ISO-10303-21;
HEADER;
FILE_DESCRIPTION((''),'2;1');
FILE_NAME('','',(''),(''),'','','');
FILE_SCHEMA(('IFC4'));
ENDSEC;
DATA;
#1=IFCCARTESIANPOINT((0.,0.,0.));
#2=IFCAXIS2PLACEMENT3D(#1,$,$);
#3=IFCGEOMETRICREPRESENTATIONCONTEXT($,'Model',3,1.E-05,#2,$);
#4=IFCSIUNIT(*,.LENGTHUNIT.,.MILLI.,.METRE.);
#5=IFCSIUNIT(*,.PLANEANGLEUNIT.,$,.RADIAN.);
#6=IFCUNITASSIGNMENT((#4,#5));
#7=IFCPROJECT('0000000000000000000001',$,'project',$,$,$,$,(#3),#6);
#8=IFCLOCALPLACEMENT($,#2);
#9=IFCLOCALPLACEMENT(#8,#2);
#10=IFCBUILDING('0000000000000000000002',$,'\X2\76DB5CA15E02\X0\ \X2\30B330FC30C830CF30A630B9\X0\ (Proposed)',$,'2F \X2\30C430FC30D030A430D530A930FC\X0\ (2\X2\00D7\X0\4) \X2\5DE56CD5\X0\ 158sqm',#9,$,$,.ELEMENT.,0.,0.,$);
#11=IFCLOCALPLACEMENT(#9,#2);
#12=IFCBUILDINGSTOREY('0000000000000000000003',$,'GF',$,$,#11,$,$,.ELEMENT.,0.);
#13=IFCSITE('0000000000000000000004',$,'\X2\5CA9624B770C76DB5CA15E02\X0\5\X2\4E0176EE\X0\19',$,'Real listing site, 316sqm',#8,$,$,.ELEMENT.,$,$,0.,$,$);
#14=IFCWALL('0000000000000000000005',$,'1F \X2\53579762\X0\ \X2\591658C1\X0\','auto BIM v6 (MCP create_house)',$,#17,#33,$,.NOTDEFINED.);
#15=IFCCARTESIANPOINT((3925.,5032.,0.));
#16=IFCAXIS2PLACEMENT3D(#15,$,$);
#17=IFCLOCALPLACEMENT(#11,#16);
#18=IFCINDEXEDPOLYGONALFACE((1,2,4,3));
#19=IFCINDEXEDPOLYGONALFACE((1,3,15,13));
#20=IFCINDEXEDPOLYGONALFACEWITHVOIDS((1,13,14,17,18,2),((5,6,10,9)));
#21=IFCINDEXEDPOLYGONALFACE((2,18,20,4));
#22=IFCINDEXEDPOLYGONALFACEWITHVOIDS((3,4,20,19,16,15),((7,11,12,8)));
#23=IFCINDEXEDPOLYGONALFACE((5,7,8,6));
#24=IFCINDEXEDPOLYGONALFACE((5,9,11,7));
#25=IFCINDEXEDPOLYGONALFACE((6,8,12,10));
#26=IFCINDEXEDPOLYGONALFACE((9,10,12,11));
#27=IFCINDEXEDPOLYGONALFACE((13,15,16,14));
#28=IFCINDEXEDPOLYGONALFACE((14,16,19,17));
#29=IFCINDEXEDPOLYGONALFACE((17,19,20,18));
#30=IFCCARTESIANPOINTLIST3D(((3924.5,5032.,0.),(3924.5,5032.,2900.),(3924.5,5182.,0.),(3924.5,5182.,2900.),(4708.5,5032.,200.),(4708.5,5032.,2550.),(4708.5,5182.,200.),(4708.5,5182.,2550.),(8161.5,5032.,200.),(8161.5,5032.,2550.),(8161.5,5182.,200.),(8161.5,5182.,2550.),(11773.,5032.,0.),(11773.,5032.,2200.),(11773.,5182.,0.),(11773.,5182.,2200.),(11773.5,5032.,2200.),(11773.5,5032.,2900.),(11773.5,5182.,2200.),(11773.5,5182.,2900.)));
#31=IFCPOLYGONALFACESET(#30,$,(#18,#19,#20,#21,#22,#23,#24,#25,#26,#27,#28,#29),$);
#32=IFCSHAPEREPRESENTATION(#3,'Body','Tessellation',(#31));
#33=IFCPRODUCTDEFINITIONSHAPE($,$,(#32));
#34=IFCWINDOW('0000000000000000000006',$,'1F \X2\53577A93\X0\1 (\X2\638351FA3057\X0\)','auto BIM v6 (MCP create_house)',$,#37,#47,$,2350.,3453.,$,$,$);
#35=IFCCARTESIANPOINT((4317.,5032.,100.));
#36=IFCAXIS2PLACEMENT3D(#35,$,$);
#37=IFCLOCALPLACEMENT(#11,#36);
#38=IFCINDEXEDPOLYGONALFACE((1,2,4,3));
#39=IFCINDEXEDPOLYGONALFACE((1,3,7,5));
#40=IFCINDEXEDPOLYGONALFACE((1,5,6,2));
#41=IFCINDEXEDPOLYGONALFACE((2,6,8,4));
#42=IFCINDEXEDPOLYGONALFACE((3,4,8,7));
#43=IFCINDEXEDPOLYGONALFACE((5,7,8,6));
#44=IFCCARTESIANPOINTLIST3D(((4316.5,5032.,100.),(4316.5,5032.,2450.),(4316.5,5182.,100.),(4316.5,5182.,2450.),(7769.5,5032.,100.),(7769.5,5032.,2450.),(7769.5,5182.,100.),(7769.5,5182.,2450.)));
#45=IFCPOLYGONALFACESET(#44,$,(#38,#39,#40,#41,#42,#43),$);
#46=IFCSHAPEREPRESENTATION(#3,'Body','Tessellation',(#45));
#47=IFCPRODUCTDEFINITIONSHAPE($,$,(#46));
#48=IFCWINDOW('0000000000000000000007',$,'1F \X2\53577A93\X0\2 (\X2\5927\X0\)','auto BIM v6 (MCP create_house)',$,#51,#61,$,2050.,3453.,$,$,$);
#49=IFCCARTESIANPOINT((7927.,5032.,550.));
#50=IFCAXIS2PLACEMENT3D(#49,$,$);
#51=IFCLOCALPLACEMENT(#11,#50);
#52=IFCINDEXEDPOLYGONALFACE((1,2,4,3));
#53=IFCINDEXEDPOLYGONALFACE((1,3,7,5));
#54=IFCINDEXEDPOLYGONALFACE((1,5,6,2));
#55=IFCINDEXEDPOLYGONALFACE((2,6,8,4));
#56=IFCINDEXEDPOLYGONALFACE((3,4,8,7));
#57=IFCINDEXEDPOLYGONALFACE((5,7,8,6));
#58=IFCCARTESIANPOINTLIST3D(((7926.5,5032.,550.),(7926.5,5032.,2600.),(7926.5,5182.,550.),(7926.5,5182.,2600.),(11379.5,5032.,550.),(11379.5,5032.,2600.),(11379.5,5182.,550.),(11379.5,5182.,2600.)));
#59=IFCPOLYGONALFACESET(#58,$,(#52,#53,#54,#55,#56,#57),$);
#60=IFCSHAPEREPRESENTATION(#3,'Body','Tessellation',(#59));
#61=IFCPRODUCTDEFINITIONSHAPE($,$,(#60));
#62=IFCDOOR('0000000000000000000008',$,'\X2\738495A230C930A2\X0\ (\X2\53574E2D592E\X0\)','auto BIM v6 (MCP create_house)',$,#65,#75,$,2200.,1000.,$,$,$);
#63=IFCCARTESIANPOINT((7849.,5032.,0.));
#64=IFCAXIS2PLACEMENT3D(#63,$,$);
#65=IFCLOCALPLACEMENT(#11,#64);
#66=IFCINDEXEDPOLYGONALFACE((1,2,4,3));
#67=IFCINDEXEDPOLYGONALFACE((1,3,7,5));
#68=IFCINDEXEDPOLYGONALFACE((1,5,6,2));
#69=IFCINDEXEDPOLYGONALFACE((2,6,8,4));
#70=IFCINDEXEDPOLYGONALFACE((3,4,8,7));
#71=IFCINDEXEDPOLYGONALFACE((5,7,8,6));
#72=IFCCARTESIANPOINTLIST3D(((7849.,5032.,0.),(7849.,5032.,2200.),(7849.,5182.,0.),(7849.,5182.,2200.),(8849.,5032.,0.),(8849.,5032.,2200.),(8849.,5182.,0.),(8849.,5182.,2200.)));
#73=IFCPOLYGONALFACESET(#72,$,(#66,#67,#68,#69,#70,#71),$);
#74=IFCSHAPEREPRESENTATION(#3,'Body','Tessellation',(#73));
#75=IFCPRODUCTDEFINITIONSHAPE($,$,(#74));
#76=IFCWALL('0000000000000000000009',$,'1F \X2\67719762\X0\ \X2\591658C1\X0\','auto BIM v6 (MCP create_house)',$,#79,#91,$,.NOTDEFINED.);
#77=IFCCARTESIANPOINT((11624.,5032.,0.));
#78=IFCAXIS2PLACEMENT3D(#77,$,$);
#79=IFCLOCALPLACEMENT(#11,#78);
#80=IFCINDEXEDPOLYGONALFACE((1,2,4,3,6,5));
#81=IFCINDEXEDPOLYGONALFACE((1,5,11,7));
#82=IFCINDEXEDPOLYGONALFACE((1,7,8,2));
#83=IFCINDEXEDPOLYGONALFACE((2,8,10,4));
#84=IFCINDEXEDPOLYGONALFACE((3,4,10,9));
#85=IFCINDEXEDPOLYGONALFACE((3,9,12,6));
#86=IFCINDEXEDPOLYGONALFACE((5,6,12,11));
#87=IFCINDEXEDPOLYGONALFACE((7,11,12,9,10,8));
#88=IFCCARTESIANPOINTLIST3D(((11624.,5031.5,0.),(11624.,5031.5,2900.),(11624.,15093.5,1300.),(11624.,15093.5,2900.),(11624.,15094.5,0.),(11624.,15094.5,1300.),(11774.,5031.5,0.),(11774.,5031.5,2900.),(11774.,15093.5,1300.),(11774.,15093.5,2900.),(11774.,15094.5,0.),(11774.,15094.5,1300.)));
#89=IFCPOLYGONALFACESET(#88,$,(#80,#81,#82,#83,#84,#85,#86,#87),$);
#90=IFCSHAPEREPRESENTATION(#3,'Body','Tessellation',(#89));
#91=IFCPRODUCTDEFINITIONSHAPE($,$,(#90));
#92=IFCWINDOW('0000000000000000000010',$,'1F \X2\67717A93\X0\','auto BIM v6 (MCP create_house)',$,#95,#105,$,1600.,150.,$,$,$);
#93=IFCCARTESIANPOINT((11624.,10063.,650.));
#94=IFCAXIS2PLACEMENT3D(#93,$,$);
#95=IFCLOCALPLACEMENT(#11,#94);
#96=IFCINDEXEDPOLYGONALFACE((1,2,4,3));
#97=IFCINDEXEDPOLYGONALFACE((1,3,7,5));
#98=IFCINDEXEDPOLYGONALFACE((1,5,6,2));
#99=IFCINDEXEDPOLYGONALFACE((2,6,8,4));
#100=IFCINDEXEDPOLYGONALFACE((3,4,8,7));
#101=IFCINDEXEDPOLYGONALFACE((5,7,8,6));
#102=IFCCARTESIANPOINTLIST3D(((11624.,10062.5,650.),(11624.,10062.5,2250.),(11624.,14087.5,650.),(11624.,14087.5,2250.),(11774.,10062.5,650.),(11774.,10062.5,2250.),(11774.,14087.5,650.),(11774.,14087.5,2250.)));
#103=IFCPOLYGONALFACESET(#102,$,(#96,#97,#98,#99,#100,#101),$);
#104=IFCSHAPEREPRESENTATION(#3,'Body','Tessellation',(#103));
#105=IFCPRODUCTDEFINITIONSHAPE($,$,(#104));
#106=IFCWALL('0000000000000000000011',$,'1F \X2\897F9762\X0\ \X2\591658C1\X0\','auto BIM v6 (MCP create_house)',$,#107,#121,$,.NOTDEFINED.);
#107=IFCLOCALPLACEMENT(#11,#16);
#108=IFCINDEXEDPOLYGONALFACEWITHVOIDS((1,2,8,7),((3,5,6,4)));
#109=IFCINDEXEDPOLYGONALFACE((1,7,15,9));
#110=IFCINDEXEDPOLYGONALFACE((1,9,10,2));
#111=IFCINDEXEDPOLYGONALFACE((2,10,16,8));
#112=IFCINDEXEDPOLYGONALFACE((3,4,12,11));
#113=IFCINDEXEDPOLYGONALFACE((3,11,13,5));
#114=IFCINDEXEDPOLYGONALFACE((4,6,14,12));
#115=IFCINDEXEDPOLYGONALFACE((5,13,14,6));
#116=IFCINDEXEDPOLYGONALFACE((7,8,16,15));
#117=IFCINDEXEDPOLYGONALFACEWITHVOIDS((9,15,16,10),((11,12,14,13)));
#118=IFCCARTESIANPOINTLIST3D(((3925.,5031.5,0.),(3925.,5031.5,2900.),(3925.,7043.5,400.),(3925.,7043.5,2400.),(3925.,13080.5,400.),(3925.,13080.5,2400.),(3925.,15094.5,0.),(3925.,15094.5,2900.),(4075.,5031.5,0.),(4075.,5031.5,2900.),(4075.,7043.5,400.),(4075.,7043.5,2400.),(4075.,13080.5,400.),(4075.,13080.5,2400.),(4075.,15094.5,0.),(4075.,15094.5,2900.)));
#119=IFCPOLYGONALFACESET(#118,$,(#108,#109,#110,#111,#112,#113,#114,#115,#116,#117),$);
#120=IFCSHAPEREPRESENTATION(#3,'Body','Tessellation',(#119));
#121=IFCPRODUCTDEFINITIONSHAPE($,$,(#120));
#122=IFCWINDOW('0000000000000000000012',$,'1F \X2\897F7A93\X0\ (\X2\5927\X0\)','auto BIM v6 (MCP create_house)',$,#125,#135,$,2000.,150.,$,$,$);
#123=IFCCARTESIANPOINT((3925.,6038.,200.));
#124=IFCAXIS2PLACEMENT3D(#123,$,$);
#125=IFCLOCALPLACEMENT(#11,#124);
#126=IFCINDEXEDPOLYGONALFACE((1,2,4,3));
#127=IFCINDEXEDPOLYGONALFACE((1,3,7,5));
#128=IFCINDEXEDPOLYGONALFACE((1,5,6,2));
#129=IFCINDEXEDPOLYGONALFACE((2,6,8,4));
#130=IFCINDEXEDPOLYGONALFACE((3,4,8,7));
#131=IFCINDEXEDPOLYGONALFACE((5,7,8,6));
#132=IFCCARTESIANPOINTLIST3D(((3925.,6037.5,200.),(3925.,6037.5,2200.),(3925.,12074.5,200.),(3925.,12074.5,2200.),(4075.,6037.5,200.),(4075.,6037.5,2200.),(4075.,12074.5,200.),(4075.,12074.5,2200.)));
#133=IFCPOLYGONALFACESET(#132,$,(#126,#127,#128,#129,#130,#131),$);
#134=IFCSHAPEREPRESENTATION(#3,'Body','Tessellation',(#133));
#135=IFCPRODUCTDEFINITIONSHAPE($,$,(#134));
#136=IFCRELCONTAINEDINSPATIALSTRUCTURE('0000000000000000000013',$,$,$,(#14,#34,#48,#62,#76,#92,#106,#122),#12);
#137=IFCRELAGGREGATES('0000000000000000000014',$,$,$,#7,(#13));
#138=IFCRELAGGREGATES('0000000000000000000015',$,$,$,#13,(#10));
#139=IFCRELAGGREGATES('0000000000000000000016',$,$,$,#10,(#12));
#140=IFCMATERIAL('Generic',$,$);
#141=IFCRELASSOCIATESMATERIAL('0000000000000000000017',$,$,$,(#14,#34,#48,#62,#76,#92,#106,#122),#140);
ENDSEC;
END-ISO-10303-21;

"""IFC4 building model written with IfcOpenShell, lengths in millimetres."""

from ifc_helpers import new_model, si_unit, frame, frame_2d, origin, place, context, project, spatial, rectangle, extrude, material, element, fill, save


model = new_model("IFC4")

# Units and contexts
model_context = context("Model", 3, precision=1e-05, world=origin())
ifc_project = project(units=[si_unit("LENGTHUNIT", "METRE", prefix="MILLI"), si_unit("PLANEANGLEUNIT", "RADIAN")], contexts=[model_context])

# Site, building, storey
site_placement = place(None, origin())
site = spatial("IfcSite", under=ifc_project, at=site_placement, Name="岩手県盛岡市5丁目19", ObjectType="Real listing site, 316sqm", CompositionType="ELEMENT", RefElevation=0.0)
building_placement = place(site_placement, origin())
building = spatial("IfcBuilding", under=site, at=building_placement, Name="盛岡市 コートハウス (Proposed)", ObjectType="2F ツーバイフォー (2×4) 工法 158sqm", CompositionType="ELEMENT", ElevationOfRefHeight=0.0, ElevationOfTerrain=0.0)
storey_placement = place(building_placement, origin())
storey = spatial("IfcBuildingStorey", under=building, at=storey_placement, Name="GF", CompositionType="ELEMENT", Elevation=0.0)

# Shared definitions
ifc_material = material(Name="Generic")

# Wall, openings, windows, door
wall_1_placement = place(storey_placement, frame((3925.0, 5032.0, 0.0)))
wall_1 = element("IfcWall", 1, at=wall_1_placement, inside=storey, material=ifc_material, Name="1F 南面 外壁", Description="auto BIM v6 (MCP create_house)", PredefinedType="NOTDEFINED", context=model_context, shape_type="SweptSolid", body=[
    extrude(rectangle(XDim=7849.0, YDim=150.0, at=frame_2d((3924.0, 75.0))), frame((3925.0, 5032.0, 0.0)), (0.0, 0.0, 1.0), 2900.0),
])
opening_1_placement = place(storey_placement, frame((4317.0, 5032.0, 100.0)))
opening_1 = element("IfcOpeningElement", 2, at=opening_1_placement, cuts=wall_1, PredefinedType="NOTDEFINED", context=model_context, shape_type="SweptSolid", body=[
    extrude(rectangle(XDim=3453.0, YDim=150.0, at=frame_2d((1726.0, 75.0))), frame((4317.0, 5032.0, 100.0)), (0.0, 0.0, 1.0), 2350.0),
])
opening_2_placement = place(storey_placement, frame((7927.0, 5032.0, 550.0)))
opening_2 = element("IfcOpeningElement", 3, at=opening_2_placement, cuts=wall_1, PredefinedType="NOTDEFINED", context=model_context, shape_type="SweptSolid", body=[
    extrude(rectangle(XDim=3453.0, YDim=150.0, at=frame_2d((1726.0, 75.0))), frame((7927.0, 5032.0, 550.0)), (0.0, 0.0, 1.0), 2050.0),
])
opening_3_placement = place(storey_placement, frame((7849.0, 5032.0, 0.0)))
opening_3 = element("IfcOpeningElement", 4, at=opening_3_placement, cuts=wall_1, PredefinedType="NOTDEFINED", context=model_context, shape_type="SweptSolid", body=[
    extrude(rectangle(XDim=1000.0, YDim=150.0, at=frame_2d((500.0, 75.0))), frame((7849.0, 5032.0, 0.0)), (0.0, 0.0, 1.0), 2200.0),
])
window_1_placement = place(storey_placement, frame((4317.0, 5032.0, 100.0)))
window_1 = element("IfcWindow", 5, at=window_1_placement, inside=storey, material=ifc_material, Name="1F 南窓1 (掃出し)", Description="auto BIM v6 (MCP create_house)", OverallHeight=2350.0, OverallWidth=3453.0, context=model_context, shape_type="SweptSolid", body=[
    extrude(rectangle(XDim=3453.0, YDim=150.0, at=frame_2d((1726.0, 75.0))), frame((4317.0, 5032.0, 100.0)), (0.0, 0.0, 1.0), 2350.0),
])
fill(opening_1, window_1)
window_2_placement = place(storey_placement, frame((7927.0, 5032.0, 550.0)))
window_2 = element("IfcWindow", 6, at=window_2_placement, inside=storey, material=ifc_material, Name="1F 南窓2 (大)", Description="auto BIM v6 (MCP create_house)", OverallHeight=2050.0, OverallWidth=3453.0, context=model_context, shape_type="SweptSolid", body=[
    extrude(rectangle(XDim=3453.0, YDim=150.0, at=frame_2d((1726.0, 75.0))), frame((7927.0, 5032.0, 550.0)), (0.0, 0.0, 1.0), 2050.0),
])
fill(opening_2, window_2)
door_placement = place(storey_placement, frame((7849.0, 5032.0, 0.0)))
door = element("IfcDoor", 7, at=door_placement, inside=storey, material=ifc_material, Name="玄関ドア (南中央)", Description="auto BIM v6 (MCP create_house)", OverallHeight=2200.0, OverallWidth=1000.0, context=model_context, shape_type="SweptSolid", body=[
    extrude(rectangle(XDim=1000.0, YDim=150.0, at=frame_2d((500.0, 75.0))), frame((7849.0, 5032.0, 0.0)), (0.0, 0.0, 1.0), 2200.0),
])
fill(opening_3, door)

# Walls, openings, windows
wall_2_placement = place(storey_placement, frame((11624.0, 5032.0, 0.0)))
wall_2 = element("IfcWall", 8, at=wall_2_placement, inside=storey, material=ifc_material, Name="1F 東面 外壁", Description="auto BIM v6 (MCP create_house)", PredefinedType="NOTDEFINED", context=model_context, shape_type="SweptSolid", body=[
    extrude(rectangle(XDim=150.0, YDim=10063.0, at=frame_2d((75.0, 5031.0))), frame((11624.0, 5032.0, 0.0)), (0.0, 0.0, 1.0), 2900.0),
])
opening_4_placement = place(storey_placement, frame((11624.0, 10063.0, 650.0)))
opening_4 = element("IfcOpeningElement", 9, at=opening_4_placement, cuts=wall_2, PredefinedType="NOTDEFINED", context=model_context, shape_type="SweptSolid", body=[
    extrude(rectangle(XDim=150.0, YDim=4025.0, at=frame_2d((75.0, 2012.0))), frame((11624.0, 10063.0, 650.0)), (0.0, 0.0, 1.0), 1600.0),
])
window_3_placement = place(storey_placement, frame((11624.0, 10063.0, 650.0)))
window_3 = element("IfcWindow", 10, at=window_3_placement, inside=storey, material=ifc_material, Name="1F 東窓", Description="auto BIM v6 (MCP create_house)", OverallHeight=1600.0, OverallWidth=150.0, context=model_context, shape_type="SweptSolid", body=[
    extrude(rectangle(XDim=150.0, YDim=4025.0, at=frame_2d((75.0, 2012.0))), frame((11624.0, 10063.0, 650.0)), (0.0, 0.0, 1.0), 1600.0),
])
fill(opening_4, window_3)
wall_3_placement = place(storey_placement, frame((3925.0, 5032.0, 0.0)))
wall_3 = element("IfcWall", 11, at=wall_3_placement, inside=storey, material=ifc_material, Name="1F 西面 外壁", Description="auto BIM v6 (MCP create_house)", PredefinedType="NOTDEFINED", context=model_context, shape_type="SweptSolid", body=[
    extrude(rectangle(XDim=150.0, YDim=10063.0, at=frame_2d((75.0, 5031.0))), frame((3925.0, 5032.0, 0.0)), (0.0, 0.0, 1.0), 2900.0),
])
opening_5_placement = place(storey_placement, frame((3925.0, 6038.0, 200.0)))
opening_5 = element("IfcOpeningElement", 12, at=opening_5_placement, cuts=wall_3, PredefinedType="NOTDEFINED", context=model_context, shape_type="SweptSolid", body=[
    extrude(rectangle(XDim=150.0, YDim=6037.0, at=frame_2d((75.0, 3018.0))), frame((3925.0, 6038.0, 200.0)), (0.0, 0.0, 1.0), 2000.0),
])
window_4_placement = place(storey_placement, frame((3925.0, 6038.0, 200.0)))
window_4 = element("IfcWindow", 13, at=window_4_placement, inside=storey, material=ifc_material, Name="1F 西窓 (大)", Description="auto BIM v6 (MCP create_house)", OverallHeight=2000.0, OverallWidth=150.0, context=model_context, shape_type="SweptSolid", body=[
    extrude(rectangle(XDim=150.0, YDim=6037.0, at=frame_2d((75.0, 3018.0))), frame((3925.0, 6038.0, 200.0)), (0.0, 0.0, 1.0), 2000.0),
])
fill(opening_5, window_4)

save(model, "model.ifc")
